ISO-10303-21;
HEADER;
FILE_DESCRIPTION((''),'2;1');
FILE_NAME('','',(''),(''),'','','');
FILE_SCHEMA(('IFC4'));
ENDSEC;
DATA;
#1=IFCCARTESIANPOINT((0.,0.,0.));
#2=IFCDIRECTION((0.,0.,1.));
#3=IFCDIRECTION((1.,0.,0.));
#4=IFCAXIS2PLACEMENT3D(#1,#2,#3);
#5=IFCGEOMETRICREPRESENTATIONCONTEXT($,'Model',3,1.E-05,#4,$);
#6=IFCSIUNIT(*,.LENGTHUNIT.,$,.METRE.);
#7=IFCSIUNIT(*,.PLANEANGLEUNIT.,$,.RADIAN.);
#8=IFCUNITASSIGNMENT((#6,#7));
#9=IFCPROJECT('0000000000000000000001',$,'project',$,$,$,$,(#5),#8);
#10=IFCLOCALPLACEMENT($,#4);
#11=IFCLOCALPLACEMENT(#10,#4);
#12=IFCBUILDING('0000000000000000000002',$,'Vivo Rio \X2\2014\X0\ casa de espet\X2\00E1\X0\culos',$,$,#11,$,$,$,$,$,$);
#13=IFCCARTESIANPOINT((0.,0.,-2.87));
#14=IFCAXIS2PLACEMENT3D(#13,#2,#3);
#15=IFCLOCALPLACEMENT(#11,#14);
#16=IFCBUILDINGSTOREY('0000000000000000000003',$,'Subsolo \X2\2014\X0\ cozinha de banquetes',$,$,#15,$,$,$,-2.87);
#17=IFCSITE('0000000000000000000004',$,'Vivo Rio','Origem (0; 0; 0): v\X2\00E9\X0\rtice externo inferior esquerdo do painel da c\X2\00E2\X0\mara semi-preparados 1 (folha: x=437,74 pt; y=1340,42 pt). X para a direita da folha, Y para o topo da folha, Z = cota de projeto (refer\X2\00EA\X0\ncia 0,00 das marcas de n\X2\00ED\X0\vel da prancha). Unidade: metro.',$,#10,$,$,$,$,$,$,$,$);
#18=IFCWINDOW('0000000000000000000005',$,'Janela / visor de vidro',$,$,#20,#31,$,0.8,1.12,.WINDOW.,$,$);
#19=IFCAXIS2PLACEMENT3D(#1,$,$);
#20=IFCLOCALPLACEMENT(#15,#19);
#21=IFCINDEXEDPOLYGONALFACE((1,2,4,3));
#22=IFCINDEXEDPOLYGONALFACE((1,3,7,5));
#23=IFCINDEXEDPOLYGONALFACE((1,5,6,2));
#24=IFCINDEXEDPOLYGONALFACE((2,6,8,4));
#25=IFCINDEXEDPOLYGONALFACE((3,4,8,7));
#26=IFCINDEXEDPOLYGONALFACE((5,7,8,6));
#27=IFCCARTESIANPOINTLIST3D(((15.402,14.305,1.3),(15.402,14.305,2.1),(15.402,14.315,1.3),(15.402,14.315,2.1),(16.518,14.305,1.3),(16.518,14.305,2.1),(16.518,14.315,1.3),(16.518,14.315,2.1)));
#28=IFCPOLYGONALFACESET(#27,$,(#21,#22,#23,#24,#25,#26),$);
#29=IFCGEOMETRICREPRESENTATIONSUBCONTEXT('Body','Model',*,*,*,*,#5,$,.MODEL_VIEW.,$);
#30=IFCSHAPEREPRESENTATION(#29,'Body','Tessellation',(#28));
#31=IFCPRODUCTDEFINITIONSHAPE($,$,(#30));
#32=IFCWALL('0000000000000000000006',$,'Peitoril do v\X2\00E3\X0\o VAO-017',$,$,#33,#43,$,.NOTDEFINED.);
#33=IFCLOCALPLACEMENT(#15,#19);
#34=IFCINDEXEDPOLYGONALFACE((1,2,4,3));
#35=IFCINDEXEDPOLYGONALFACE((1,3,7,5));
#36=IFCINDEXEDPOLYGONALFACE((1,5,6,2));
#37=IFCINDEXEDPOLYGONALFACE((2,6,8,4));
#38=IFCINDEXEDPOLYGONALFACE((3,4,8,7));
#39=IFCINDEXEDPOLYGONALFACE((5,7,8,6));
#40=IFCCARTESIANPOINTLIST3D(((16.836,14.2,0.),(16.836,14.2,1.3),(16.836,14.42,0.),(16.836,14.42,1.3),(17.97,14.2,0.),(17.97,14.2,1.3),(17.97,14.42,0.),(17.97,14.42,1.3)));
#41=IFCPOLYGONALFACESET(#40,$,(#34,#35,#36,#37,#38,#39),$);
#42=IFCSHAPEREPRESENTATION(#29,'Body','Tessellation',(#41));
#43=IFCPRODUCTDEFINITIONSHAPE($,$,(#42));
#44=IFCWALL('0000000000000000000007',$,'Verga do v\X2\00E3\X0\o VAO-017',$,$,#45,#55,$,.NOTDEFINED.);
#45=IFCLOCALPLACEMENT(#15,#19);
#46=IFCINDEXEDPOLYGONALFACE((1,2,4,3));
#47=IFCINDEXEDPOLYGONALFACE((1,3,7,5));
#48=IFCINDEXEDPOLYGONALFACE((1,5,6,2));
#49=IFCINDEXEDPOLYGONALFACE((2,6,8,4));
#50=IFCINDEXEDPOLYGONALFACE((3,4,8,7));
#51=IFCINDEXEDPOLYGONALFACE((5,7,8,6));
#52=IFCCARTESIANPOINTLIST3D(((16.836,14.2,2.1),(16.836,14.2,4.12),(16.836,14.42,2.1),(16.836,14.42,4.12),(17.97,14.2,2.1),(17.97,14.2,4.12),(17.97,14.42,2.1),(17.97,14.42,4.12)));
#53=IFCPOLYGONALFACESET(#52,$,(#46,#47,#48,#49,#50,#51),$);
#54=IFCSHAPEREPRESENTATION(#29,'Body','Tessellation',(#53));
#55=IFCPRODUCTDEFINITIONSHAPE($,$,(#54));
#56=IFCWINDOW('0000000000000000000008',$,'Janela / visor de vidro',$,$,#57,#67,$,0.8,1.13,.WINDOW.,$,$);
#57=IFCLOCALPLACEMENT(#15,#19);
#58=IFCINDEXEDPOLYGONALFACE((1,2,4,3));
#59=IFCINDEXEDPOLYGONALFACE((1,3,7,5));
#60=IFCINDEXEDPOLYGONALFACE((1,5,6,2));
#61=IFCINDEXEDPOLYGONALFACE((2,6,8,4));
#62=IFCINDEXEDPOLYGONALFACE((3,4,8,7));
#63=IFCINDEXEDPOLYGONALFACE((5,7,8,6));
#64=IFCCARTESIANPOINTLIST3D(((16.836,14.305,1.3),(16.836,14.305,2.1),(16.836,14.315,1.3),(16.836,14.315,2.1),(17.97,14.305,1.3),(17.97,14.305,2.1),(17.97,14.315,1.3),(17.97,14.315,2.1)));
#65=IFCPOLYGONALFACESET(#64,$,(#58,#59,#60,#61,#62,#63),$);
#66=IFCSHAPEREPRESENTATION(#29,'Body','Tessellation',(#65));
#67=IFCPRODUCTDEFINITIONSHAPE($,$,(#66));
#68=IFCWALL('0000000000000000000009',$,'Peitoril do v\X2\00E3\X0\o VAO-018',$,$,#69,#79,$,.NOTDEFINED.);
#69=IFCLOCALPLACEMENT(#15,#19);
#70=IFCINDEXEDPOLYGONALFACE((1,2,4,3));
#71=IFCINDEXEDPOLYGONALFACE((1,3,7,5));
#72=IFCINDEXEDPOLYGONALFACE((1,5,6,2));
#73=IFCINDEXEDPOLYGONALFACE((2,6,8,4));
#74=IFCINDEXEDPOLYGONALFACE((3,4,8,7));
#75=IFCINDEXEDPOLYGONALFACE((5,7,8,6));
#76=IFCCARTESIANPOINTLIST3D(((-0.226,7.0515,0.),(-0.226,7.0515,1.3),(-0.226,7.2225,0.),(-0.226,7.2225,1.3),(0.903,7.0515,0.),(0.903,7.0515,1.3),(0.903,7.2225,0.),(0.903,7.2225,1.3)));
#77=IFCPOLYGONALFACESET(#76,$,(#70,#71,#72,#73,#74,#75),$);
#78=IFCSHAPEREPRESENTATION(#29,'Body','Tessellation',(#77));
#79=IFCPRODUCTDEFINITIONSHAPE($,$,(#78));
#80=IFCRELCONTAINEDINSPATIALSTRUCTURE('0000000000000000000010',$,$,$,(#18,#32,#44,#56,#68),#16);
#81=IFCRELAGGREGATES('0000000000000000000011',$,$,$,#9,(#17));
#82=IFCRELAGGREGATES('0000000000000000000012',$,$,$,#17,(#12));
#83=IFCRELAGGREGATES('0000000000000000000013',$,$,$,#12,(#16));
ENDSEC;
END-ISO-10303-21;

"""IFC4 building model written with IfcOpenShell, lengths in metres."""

from ifc_helpers import new_model, si_unit, frame, origin_with_axes, origin_2d, place, context, subcontext, project, spatial, rectangle, extrude, element, save


model = new_model("IFC4")

# Units and contexts
model_context = context("Model", 3, precision=1e-05, world=origin_with_axes())
body_context = subcontext(model_context, "Body", "Model", "MODEL_VIEW")
ifc_project = project(units=[si_unit("LENGTHUNIT", "METRE"), si_unit("PLANEANGLEUNIT", "RADIAN")], contexts=[model_context])

# Site, building, storey
site_placement = place(None, origin_with_axes())
site = spatial("IfcSite", under=ifc_project, at=site_placement, Name="Vivo Rio", Description="Origem (0; 0; 0): vértice externo inferior esquerdo do painel da câmara semi-preparados 1 (folha: x=437,74 pt; y=1340,42 pt). X para a direita da folha, Y para o topo da folha, Z = cota de projeto (referência 0,00 das marcas de nível da prancha). Unidade: metro.")
building_placement = place(site_placement, origin_with_axes())
building = spatial("IfcBuilding", under=site, at=building_placement, Name="Vivo Rio — casa de espetáculos")
storey_placement = place(building_placement, frame((0.0, 0.0, -2.87), z_axis=(0.0, 0.0, 1.0), x_axis=(1.0, 0.0, 0.0)))
storey = spatial("IfcBuildingStorey", under=building, at=storey_placement, Name="Subsolo — cozinha de banquetes", Elevation=-2.87)

# Window
window_1_placement = place(storey_placement, origin_with_axes())
element("IfcWindow", 1, at=window_1_placement, inside=storey, Name="Janela / visor de vidro", OverallHeight=0.8, OverallWidth=1.12, PredefinedType="WINDOW", context=body_context, shape_type="SweptSolid", body=[
    extrude(rectangle(XDim=1.116, YDim=0.01, at=origin_2d()), frame((15.96, 14.31, 1.3), z_axis=(0.0, 0.0, 1.0), x_axis=(1.0, 0.0, 0.0)), (0.0, 0.0, 1.0), 0.8),
])

# Walls
wall_1_placement = place(storey_placement, origin_with_axes())
element("IfcWall", 2, at=wall_1_placement, inside=storey, Name="Peitoril do vão VAO-017", PredefinedType="NOTDEFINED", context=body_context, shape_type="SweptSolid", body=[
    extrude(rectangle(XDim=1.134, YDim=0.22, at=origin_2d()), frame((17.403, 14.31, 0.0), z_axis=(0.0, 0.0, 1.0), x_axis=(1.0, 0.0, 0.0)), (0.0, 0.0, 1.0), 1.3),
])
wall_2_placement = place(storey_placement, origin_with_axes())
element("IfcWall", 3, at=wall_2_placement, inside=storey, Name="Verga do vão VAO-017", PredefinedType="NOTDEFINED", context=body_context, shape_type="SweptSolid", body=[
    extrude(rectangle(XDim=1.134, YDim=0.22, at=origin_2d()), frame((17.403, 14.31, 2.1), z_axis=(0.0, 0.0, 1.0), x_axis=(1.0, 0.0, 0.0)), (0.0, 0.0, 1.0), 2.02),
])

# Window
window_2_placement = place(storey_placement, origin_with_axes())
element("IfcWindow", 4, at=window_2_placement, inside=storey, Name="Janela / visor de vidro", OverallHeight=0.8, OverallWidth=1.13, PredefinedType="WINDOW", context=body_context, shape_type="SweptSolid", body=[
    extrude(rectangle(XDim=1.134, YDim=0.01, at=origin_2d()), frame((17.403, 14.31, 1.3), z_axis=(0.0, 0.0, 1.0), x_axis=(1.0, 0.0, 0.0)), (0.0, 0.0, 1.0), 0.8),
])

# Wall
wall_3_placement = place(storey_placement, origin_with_axes())
element("IfcWall", 5, at=wall_3_placement, inside=storey, Name="Peitoril do vão VAO-018", PredefinedType="NOTDEFINED", context=body_context, shape_type="SweptSolid", body=[
    extrude(rectangle(XDim=1.129, YDim=0.171, at=origin_2d()), frame((0.3385, 7.137, 0.0), z_axis=(0.0, 0.0, 1.0), x_axis=(1.0, 0.0, 0.0)), (0.0, 0.0, 1.0), 1.3),
])

save(model, "model.ifc")
